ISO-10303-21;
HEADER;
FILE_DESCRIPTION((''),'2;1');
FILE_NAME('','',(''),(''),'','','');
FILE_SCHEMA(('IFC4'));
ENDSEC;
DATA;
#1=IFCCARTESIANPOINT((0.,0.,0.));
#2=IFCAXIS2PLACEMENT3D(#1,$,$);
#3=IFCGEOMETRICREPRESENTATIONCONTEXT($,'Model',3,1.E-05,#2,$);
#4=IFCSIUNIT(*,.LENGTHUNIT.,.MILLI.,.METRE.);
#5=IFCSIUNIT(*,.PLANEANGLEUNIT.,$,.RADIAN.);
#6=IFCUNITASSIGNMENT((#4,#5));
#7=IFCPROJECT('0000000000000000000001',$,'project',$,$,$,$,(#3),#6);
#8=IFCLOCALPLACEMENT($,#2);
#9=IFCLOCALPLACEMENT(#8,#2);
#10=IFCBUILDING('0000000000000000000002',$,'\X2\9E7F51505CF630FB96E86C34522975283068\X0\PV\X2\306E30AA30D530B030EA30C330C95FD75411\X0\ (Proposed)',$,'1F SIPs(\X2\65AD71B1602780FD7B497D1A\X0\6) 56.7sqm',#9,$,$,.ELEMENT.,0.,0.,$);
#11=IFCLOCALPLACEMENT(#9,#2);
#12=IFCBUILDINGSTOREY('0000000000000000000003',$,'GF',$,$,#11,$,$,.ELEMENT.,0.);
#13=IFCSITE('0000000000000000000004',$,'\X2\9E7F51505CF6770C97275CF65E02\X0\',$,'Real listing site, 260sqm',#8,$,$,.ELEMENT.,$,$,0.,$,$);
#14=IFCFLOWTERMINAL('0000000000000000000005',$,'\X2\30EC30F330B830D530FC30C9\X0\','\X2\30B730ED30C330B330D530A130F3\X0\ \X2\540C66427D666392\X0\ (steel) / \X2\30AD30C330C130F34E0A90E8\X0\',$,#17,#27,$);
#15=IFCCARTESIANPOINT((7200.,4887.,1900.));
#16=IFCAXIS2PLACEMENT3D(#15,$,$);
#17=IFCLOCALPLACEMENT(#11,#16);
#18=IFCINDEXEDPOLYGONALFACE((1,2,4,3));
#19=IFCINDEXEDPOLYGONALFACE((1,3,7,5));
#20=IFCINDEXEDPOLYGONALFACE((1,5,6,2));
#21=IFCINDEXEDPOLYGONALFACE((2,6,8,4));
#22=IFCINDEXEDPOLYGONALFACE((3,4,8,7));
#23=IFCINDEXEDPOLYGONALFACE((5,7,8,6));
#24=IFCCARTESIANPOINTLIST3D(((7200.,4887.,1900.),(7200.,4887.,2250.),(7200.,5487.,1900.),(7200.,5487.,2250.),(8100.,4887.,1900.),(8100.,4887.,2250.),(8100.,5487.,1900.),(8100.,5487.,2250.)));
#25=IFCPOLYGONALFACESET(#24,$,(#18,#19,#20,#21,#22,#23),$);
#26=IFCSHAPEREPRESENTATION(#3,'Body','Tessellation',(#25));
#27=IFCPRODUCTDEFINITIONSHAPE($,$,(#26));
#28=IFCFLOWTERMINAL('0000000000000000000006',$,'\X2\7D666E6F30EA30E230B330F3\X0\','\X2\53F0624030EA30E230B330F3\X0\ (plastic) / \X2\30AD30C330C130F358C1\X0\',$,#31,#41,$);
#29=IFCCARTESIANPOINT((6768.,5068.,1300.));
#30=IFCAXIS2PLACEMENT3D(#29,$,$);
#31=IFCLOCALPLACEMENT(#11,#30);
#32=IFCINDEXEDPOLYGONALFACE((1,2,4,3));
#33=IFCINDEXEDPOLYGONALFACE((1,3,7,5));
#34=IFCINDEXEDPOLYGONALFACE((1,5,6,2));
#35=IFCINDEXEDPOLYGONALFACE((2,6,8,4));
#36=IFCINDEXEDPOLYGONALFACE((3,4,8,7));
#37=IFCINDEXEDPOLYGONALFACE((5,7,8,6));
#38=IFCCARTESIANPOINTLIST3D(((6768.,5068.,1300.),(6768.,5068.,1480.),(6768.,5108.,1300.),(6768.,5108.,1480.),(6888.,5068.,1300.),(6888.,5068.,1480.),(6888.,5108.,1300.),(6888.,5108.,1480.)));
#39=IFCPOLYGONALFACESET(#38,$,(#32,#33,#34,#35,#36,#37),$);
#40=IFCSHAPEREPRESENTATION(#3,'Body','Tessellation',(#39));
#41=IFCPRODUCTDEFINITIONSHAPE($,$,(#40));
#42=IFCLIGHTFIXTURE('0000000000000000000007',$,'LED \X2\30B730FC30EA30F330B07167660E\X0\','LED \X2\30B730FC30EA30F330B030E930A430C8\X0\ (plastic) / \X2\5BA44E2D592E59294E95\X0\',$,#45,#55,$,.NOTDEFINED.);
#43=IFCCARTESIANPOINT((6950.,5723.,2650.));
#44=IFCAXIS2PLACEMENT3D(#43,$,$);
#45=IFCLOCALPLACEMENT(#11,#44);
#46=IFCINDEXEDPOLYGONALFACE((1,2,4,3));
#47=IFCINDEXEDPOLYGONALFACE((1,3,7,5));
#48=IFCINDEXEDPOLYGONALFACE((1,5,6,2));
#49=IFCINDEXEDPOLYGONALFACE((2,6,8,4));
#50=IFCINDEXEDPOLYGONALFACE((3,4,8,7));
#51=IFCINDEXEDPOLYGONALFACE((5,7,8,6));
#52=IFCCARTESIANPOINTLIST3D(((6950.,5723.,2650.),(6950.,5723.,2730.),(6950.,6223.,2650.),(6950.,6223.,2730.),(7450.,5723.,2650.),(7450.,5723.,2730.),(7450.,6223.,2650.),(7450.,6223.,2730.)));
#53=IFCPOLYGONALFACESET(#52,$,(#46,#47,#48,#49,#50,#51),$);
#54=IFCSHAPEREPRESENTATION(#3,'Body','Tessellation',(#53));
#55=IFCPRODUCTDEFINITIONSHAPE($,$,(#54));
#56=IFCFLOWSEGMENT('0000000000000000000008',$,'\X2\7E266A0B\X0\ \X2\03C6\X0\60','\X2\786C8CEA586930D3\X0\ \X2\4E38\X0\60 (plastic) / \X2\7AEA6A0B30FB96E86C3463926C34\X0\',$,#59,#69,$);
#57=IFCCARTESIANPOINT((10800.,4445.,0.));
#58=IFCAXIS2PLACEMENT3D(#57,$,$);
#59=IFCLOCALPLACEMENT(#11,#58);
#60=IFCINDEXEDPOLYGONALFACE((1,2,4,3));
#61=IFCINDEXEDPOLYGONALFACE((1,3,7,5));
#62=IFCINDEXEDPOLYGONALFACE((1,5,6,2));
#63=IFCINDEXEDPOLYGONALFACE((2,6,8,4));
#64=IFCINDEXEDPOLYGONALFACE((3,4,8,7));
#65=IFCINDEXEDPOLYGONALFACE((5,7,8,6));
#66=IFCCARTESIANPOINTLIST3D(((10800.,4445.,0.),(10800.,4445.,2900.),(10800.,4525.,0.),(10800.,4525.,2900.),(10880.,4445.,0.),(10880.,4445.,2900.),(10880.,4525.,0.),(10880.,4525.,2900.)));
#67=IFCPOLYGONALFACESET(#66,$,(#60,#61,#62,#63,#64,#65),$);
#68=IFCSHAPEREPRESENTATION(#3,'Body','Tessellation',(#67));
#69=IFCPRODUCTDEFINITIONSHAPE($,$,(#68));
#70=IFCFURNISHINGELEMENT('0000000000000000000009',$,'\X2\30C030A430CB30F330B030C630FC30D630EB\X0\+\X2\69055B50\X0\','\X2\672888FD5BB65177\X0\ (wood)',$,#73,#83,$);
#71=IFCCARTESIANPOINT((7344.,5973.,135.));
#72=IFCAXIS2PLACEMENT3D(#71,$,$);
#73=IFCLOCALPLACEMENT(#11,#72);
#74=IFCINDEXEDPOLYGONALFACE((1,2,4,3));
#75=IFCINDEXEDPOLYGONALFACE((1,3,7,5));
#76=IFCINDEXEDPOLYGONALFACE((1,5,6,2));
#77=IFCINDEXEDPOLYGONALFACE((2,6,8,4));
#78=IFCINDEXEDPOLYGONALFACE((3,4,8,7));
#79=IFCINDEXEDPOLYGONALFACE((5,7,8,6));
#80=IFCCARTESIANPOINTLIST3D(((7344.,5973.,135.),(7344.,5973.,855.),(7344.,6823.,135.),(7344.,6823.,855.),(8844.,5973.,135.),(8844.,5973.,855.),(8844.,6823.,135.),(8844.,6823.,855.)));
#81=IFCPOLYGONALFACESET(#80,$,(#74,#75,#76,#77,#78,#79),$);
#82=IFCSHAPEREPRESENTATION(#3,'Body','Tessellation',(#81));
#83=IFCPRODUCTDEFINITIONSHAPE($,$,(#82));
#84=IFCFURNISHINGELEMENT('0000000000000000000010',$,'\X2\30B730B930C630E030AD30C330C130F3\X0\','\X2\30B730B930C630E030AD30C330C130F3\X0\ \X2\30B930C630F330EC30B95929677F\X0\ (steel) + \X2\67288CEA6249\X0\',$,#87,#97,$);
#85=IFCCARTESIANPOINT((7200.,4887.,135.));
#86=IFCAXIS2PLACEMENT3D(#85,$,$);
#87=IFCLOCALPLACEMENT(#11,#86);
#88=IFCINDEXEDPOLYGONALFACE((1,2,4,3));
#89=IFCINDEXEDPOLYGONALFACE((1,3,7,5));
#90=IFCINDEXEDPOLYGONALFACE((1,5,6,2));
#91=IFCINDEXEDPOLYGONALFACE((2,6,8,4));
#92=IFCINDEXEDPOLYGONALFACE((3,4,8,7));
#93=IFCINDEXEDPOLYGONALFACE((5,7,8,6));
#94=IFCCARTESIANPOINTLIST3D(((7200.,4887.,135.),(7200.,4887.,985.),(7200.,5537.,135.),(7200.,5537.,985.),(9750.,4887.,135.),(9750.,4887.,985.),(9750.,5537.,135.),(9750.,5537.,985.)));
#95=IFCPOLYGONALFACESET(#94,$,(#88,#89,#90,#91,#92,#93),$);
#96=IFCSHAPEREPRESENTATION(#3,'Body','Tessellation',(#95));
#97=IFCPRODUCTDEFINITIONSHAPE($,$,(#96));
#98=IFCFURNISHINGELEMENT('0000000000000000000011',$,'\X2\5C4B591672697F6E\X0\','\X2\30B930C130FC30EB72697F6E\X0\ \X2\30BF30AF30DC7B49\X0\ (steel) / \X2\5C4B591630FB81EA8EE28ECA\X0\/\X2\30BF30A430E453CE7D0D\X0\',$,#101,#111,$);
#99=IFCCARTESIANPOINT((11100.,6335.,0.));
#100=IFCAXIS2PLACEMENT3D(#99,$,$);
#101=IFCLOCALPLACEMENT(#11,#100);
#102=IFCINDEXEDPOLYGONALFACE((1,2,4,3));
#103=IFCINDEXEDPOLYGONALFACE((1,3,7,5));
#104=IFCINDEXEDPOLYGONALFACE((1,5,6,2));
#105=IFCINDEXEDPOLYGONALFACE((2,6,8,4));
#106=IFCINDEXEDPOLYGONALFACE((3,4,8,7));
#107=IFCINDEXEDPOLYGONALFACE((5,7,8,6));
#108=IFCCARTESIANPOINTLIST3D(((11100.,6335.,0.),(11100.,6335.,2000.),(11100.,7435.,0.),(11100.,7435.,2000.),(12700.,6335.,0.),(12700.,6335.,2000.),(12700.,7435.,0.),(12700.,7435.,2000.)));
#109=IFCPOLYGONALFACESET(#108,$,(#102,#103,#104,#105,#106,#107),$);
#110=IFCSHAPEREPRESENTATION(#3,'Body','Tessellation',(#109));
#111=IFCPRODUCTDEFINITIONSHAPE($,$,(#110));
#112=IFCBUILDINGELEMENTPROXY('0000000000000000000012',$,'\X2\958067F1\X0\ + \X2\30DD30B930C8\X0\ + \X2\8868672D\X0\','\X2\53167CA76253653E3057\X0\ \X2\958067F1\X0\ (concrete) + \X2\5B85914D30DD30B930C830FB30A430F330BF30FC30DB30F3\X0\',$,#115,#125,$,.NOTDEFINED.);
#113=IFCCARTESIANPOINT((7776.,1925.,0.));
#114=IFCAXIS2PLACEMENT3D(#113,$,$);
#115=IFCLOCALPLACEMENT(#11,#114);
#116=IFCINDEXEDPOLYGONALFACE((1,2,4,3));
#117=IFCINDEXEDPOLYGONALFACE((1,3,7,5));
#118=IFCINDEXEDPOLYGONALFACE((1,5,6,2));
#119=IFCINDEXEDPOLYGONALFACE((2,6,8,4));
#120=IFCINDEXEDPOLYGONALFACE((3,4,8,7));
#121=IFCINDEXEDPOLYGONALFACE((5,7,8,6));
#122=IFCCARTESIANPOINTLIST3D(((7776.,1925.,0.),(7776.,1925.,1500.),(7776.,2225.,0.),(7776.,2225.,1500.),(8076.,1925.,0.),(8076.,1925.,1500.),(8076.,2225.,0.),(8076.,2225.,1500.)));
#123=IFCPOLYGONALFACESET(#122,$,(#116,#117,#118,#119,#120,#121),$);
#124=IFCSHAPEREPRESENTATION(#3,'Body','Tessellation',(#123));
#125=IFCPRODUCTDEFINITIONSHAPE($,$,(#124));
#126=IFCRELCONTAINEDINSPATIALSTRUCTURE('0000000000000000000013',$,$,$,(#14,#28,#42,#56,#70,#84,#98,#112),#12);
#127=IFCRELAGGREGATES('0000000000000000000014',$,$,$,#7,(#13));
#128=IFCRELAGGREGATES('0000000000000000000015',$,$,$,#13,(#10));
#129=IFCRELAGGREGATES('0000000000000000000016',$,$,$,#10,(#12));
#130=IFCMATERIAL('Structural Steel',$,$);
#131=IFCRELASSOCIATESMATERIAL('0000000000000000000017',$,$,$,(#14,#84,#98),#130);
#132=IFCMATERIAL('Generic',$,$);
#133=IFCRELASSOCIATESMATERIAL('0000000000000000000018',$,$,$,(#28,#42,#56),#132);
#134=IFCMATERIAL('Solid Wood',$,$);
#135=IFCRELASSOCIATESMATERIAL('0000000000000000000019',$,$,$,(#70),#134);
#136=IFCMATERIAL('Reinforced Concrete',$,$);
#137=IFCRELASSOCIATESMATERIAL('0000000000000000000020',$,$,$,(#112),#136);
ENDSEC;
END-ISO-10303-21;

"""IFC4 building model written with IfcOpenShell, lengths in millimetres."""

from ifc_helpers import new_model, si_unit, frame, frame_2d, origin, place, context, project, spatial, rectangle, extrude, material, element, save


model = new_model("IFC4")

# Units and contexts
model_context = context("Model", 3, precision=1e-05, world=origin())
ifc_project = project(units=[si_unit("LENGTHUNIT", "METRE", prefix="MILLI"), si_unit("PLANEANGLEUNIT", "RADIAN")], contexts=[model_context])

# Site, building, storey
site_placement = place(None, origin())
site = spatial("IfcSite", under=ifc_project, at=site_placement, Name="鹿児島県霧島市", ObjectType="Real listing site, 260sqm", CompositionType="ELEMENT", RefElevation=0.0)
building_placement = place(site_placement, origin())
building = spatial("IfcBuilding", under=site, at=building_placement, Name="鹿児島・雨水利用とPVのオフグリッド志向 (Proposed)", ObjectType="1F SIPs(断熱性能等級6) 56.7sqm", CompositionType="ELEMENT", ElevationOfRefHeight=0.0, ElevationOfTerrain=0.0)
storey_placement = place(building_placement, origin())
storey = spatial("IfcBuildingStorey", under=building, at=storey_placement, Name="GF", CompositionType="ELEMENT", Elevation=0.0)

# Shared definitions
ifc_material_1 = material(Name="Solid Wood")

# Shared definitions
ifc_material_2 = material(Name="Structural Steel")

# Shared definitions
ifc_material_3 = material(Name="Reinforced Concrete")

# Flow terminals
flow_terminal_1_placement = place(storey_placement, frame((7200.0, 4887.0, 1900.0)))
element("IfcFlowTerminal", 1, at=flow_terminal_1_placement, inside=storey, material=ifc_material_2, Name="レンジフード", Description="シロッコファン 同時給排 (steel) / キッチン上部", context=model_context, shape_type="SweptSolid", body=[
    extrude(rectangle(XDim=900.0, YDim=600.0, at=frame_2d((450.0, 300.0))), frame((7200.0, 4887.0, 1900.0)), (0.0, 0.0, 1.0), 350.0),
])
ifc_material_4 = material(Name="Generic")
flow_terminal_2_placement = place(storey_placement, frame((6768.0, 5068.0, 1300.0)))
element("IfcFlowTerminal", 2, at=flow_terminal_2_placement, inside=storey, material=ifc_material_4, Name="給湯リモコン", Description="台所リモコン (plastic) / キッチン壁", context=model_context, shape_type="SweptSolid", body=[
    extrude(rectangle(XDim=120.0, YDim=40.0, at=frame_2d((60.0, 20.0))), frame((6768.0, 5068.0, 1300.0)), (0.0, 0.0, 1.0), 180.0),
])

# Light fixture
light_fixture_placement = place(storey_placement, frame((6950.0, 5723.0, 2650.0)))
element("IfcLightFixture", 3, at=light_fixture_placement, inside=storey, material=ifc_material_4, Name="LED シーリング照明", Description="LED シーリングライト (plastic) / 室中央天井", PredefinedType="NOTDEFINED", context=model_context, shape_type="SweptSolid", body=[
    extrude(rectangle(XDim=500.0, YDim=500.0, at=frame_2d((250.0, 250.0))), frame((6950.0, 5723.0, 2650.0)), (0.0, 0.0, 1.0), 80.0),
])

# Flow segment
flow_segment_placement = place(storey_placement, frame((10800.0, 4445.0, 0.0)))
element("IfcFlowSegment", 4, at=flow_segment_placement, inside=storey, material=ifc_material_4, Name="縦樋 φ60", Description="硬質塩ビ 丸60 (plastic) / 竪樋・雨水排水", context=model_context, shape_type="SweptSolid", body=[
    extrude(rectangle(XDim=80.0, YDim=80.0, at=frame_2d((40.0, 40.0))), frame((10800.0, 4445.0, 0.0)), (0.0, 0.0, 1.0), 2900.0),
])

# Furnishing elements
furnishing_1_placement = place(storey_placement, frame((7344.0, 5973.0, 135.0)))
element("IfcFurnishingElement", 5, at=furnishing_1_placement, inside=storey, material=ifc_material_1, Name="ダイニングテーブル+椅子", Description="木製家具 (wood)", context=model_context, shape_type="SweptSolid", body=[
    extrude(rectangle(XDim=1500.0, YDim=850.0, at=frame_2d((750.0, 425.0))), frame((7344.0, 5973.0, 135.0)), (0.0, 0.0, 1.0), 720.0),
])
furnishing_2_placement = place(storey_placement, frame((7200.0, 4887.0, 135.0)))
element("IfcFurnishingElement", 6, at=furnishing_2_placement, inside=storey, material=ifc_material_2, Name="システムキッチン", Description="システムキッチン ステンレス天板 (steel) + 木質扉", context=model_context, shape_type="SweptSolid", body=[
    extrude(rectangle(XDim=2550.0, YDim=650.0, at=frame_2d((1275.0, 325.0))), frame((7200.0, 4887.0, 135.0)), (0.0, 0.0, 1.0), 850.0),
])
furnishing_3_placement = place(storey_placement, frame((11100.0, 6335.0, 0.0)))
element("IfcFurnishingElement", 7, at=furnishing_3_placement, inside=storey, material=ifc_material_2, Name="屋外物置", Description="スチール物置 タクボ等 (steel) / 屋外・自転車/タイヤ収納", context=model_context, shape_type="SweptSolid", body=[
    extrude(rectangle(XDim=1600.0, YDim=1100.0, at=frame_2d((800.0, 550.0))), frame((11100.0, 6335.0, 0.0)), (0.0, 0.0, 1.0), 2000.0),
])

# Building element proxy
proxy_placement = place(storey_placement, frame((7776.0, 1925.0, 0.0)))
element("IfcBuildingElementProxy", 8, at=proxy_placement, inside=storey, material=ifc_material_3, Name="門柱 + ポスト + 表札", Description="化粧打放し 門柱 (concrete) + 宅配ポスト・インターホン", PredefinedType="NOTDEFINED", context=model_context, shape_type="SweptSolid", body=[
    extrude(rectangle(XDim=300.0, YDim=300.0, at=frame_2d((150.0, 150.0))), frame((7776.0, 1925.0, 0.0)), (0.0, 0.0, 1.0), 1500.0),
])

save(model, "model.ifc")
